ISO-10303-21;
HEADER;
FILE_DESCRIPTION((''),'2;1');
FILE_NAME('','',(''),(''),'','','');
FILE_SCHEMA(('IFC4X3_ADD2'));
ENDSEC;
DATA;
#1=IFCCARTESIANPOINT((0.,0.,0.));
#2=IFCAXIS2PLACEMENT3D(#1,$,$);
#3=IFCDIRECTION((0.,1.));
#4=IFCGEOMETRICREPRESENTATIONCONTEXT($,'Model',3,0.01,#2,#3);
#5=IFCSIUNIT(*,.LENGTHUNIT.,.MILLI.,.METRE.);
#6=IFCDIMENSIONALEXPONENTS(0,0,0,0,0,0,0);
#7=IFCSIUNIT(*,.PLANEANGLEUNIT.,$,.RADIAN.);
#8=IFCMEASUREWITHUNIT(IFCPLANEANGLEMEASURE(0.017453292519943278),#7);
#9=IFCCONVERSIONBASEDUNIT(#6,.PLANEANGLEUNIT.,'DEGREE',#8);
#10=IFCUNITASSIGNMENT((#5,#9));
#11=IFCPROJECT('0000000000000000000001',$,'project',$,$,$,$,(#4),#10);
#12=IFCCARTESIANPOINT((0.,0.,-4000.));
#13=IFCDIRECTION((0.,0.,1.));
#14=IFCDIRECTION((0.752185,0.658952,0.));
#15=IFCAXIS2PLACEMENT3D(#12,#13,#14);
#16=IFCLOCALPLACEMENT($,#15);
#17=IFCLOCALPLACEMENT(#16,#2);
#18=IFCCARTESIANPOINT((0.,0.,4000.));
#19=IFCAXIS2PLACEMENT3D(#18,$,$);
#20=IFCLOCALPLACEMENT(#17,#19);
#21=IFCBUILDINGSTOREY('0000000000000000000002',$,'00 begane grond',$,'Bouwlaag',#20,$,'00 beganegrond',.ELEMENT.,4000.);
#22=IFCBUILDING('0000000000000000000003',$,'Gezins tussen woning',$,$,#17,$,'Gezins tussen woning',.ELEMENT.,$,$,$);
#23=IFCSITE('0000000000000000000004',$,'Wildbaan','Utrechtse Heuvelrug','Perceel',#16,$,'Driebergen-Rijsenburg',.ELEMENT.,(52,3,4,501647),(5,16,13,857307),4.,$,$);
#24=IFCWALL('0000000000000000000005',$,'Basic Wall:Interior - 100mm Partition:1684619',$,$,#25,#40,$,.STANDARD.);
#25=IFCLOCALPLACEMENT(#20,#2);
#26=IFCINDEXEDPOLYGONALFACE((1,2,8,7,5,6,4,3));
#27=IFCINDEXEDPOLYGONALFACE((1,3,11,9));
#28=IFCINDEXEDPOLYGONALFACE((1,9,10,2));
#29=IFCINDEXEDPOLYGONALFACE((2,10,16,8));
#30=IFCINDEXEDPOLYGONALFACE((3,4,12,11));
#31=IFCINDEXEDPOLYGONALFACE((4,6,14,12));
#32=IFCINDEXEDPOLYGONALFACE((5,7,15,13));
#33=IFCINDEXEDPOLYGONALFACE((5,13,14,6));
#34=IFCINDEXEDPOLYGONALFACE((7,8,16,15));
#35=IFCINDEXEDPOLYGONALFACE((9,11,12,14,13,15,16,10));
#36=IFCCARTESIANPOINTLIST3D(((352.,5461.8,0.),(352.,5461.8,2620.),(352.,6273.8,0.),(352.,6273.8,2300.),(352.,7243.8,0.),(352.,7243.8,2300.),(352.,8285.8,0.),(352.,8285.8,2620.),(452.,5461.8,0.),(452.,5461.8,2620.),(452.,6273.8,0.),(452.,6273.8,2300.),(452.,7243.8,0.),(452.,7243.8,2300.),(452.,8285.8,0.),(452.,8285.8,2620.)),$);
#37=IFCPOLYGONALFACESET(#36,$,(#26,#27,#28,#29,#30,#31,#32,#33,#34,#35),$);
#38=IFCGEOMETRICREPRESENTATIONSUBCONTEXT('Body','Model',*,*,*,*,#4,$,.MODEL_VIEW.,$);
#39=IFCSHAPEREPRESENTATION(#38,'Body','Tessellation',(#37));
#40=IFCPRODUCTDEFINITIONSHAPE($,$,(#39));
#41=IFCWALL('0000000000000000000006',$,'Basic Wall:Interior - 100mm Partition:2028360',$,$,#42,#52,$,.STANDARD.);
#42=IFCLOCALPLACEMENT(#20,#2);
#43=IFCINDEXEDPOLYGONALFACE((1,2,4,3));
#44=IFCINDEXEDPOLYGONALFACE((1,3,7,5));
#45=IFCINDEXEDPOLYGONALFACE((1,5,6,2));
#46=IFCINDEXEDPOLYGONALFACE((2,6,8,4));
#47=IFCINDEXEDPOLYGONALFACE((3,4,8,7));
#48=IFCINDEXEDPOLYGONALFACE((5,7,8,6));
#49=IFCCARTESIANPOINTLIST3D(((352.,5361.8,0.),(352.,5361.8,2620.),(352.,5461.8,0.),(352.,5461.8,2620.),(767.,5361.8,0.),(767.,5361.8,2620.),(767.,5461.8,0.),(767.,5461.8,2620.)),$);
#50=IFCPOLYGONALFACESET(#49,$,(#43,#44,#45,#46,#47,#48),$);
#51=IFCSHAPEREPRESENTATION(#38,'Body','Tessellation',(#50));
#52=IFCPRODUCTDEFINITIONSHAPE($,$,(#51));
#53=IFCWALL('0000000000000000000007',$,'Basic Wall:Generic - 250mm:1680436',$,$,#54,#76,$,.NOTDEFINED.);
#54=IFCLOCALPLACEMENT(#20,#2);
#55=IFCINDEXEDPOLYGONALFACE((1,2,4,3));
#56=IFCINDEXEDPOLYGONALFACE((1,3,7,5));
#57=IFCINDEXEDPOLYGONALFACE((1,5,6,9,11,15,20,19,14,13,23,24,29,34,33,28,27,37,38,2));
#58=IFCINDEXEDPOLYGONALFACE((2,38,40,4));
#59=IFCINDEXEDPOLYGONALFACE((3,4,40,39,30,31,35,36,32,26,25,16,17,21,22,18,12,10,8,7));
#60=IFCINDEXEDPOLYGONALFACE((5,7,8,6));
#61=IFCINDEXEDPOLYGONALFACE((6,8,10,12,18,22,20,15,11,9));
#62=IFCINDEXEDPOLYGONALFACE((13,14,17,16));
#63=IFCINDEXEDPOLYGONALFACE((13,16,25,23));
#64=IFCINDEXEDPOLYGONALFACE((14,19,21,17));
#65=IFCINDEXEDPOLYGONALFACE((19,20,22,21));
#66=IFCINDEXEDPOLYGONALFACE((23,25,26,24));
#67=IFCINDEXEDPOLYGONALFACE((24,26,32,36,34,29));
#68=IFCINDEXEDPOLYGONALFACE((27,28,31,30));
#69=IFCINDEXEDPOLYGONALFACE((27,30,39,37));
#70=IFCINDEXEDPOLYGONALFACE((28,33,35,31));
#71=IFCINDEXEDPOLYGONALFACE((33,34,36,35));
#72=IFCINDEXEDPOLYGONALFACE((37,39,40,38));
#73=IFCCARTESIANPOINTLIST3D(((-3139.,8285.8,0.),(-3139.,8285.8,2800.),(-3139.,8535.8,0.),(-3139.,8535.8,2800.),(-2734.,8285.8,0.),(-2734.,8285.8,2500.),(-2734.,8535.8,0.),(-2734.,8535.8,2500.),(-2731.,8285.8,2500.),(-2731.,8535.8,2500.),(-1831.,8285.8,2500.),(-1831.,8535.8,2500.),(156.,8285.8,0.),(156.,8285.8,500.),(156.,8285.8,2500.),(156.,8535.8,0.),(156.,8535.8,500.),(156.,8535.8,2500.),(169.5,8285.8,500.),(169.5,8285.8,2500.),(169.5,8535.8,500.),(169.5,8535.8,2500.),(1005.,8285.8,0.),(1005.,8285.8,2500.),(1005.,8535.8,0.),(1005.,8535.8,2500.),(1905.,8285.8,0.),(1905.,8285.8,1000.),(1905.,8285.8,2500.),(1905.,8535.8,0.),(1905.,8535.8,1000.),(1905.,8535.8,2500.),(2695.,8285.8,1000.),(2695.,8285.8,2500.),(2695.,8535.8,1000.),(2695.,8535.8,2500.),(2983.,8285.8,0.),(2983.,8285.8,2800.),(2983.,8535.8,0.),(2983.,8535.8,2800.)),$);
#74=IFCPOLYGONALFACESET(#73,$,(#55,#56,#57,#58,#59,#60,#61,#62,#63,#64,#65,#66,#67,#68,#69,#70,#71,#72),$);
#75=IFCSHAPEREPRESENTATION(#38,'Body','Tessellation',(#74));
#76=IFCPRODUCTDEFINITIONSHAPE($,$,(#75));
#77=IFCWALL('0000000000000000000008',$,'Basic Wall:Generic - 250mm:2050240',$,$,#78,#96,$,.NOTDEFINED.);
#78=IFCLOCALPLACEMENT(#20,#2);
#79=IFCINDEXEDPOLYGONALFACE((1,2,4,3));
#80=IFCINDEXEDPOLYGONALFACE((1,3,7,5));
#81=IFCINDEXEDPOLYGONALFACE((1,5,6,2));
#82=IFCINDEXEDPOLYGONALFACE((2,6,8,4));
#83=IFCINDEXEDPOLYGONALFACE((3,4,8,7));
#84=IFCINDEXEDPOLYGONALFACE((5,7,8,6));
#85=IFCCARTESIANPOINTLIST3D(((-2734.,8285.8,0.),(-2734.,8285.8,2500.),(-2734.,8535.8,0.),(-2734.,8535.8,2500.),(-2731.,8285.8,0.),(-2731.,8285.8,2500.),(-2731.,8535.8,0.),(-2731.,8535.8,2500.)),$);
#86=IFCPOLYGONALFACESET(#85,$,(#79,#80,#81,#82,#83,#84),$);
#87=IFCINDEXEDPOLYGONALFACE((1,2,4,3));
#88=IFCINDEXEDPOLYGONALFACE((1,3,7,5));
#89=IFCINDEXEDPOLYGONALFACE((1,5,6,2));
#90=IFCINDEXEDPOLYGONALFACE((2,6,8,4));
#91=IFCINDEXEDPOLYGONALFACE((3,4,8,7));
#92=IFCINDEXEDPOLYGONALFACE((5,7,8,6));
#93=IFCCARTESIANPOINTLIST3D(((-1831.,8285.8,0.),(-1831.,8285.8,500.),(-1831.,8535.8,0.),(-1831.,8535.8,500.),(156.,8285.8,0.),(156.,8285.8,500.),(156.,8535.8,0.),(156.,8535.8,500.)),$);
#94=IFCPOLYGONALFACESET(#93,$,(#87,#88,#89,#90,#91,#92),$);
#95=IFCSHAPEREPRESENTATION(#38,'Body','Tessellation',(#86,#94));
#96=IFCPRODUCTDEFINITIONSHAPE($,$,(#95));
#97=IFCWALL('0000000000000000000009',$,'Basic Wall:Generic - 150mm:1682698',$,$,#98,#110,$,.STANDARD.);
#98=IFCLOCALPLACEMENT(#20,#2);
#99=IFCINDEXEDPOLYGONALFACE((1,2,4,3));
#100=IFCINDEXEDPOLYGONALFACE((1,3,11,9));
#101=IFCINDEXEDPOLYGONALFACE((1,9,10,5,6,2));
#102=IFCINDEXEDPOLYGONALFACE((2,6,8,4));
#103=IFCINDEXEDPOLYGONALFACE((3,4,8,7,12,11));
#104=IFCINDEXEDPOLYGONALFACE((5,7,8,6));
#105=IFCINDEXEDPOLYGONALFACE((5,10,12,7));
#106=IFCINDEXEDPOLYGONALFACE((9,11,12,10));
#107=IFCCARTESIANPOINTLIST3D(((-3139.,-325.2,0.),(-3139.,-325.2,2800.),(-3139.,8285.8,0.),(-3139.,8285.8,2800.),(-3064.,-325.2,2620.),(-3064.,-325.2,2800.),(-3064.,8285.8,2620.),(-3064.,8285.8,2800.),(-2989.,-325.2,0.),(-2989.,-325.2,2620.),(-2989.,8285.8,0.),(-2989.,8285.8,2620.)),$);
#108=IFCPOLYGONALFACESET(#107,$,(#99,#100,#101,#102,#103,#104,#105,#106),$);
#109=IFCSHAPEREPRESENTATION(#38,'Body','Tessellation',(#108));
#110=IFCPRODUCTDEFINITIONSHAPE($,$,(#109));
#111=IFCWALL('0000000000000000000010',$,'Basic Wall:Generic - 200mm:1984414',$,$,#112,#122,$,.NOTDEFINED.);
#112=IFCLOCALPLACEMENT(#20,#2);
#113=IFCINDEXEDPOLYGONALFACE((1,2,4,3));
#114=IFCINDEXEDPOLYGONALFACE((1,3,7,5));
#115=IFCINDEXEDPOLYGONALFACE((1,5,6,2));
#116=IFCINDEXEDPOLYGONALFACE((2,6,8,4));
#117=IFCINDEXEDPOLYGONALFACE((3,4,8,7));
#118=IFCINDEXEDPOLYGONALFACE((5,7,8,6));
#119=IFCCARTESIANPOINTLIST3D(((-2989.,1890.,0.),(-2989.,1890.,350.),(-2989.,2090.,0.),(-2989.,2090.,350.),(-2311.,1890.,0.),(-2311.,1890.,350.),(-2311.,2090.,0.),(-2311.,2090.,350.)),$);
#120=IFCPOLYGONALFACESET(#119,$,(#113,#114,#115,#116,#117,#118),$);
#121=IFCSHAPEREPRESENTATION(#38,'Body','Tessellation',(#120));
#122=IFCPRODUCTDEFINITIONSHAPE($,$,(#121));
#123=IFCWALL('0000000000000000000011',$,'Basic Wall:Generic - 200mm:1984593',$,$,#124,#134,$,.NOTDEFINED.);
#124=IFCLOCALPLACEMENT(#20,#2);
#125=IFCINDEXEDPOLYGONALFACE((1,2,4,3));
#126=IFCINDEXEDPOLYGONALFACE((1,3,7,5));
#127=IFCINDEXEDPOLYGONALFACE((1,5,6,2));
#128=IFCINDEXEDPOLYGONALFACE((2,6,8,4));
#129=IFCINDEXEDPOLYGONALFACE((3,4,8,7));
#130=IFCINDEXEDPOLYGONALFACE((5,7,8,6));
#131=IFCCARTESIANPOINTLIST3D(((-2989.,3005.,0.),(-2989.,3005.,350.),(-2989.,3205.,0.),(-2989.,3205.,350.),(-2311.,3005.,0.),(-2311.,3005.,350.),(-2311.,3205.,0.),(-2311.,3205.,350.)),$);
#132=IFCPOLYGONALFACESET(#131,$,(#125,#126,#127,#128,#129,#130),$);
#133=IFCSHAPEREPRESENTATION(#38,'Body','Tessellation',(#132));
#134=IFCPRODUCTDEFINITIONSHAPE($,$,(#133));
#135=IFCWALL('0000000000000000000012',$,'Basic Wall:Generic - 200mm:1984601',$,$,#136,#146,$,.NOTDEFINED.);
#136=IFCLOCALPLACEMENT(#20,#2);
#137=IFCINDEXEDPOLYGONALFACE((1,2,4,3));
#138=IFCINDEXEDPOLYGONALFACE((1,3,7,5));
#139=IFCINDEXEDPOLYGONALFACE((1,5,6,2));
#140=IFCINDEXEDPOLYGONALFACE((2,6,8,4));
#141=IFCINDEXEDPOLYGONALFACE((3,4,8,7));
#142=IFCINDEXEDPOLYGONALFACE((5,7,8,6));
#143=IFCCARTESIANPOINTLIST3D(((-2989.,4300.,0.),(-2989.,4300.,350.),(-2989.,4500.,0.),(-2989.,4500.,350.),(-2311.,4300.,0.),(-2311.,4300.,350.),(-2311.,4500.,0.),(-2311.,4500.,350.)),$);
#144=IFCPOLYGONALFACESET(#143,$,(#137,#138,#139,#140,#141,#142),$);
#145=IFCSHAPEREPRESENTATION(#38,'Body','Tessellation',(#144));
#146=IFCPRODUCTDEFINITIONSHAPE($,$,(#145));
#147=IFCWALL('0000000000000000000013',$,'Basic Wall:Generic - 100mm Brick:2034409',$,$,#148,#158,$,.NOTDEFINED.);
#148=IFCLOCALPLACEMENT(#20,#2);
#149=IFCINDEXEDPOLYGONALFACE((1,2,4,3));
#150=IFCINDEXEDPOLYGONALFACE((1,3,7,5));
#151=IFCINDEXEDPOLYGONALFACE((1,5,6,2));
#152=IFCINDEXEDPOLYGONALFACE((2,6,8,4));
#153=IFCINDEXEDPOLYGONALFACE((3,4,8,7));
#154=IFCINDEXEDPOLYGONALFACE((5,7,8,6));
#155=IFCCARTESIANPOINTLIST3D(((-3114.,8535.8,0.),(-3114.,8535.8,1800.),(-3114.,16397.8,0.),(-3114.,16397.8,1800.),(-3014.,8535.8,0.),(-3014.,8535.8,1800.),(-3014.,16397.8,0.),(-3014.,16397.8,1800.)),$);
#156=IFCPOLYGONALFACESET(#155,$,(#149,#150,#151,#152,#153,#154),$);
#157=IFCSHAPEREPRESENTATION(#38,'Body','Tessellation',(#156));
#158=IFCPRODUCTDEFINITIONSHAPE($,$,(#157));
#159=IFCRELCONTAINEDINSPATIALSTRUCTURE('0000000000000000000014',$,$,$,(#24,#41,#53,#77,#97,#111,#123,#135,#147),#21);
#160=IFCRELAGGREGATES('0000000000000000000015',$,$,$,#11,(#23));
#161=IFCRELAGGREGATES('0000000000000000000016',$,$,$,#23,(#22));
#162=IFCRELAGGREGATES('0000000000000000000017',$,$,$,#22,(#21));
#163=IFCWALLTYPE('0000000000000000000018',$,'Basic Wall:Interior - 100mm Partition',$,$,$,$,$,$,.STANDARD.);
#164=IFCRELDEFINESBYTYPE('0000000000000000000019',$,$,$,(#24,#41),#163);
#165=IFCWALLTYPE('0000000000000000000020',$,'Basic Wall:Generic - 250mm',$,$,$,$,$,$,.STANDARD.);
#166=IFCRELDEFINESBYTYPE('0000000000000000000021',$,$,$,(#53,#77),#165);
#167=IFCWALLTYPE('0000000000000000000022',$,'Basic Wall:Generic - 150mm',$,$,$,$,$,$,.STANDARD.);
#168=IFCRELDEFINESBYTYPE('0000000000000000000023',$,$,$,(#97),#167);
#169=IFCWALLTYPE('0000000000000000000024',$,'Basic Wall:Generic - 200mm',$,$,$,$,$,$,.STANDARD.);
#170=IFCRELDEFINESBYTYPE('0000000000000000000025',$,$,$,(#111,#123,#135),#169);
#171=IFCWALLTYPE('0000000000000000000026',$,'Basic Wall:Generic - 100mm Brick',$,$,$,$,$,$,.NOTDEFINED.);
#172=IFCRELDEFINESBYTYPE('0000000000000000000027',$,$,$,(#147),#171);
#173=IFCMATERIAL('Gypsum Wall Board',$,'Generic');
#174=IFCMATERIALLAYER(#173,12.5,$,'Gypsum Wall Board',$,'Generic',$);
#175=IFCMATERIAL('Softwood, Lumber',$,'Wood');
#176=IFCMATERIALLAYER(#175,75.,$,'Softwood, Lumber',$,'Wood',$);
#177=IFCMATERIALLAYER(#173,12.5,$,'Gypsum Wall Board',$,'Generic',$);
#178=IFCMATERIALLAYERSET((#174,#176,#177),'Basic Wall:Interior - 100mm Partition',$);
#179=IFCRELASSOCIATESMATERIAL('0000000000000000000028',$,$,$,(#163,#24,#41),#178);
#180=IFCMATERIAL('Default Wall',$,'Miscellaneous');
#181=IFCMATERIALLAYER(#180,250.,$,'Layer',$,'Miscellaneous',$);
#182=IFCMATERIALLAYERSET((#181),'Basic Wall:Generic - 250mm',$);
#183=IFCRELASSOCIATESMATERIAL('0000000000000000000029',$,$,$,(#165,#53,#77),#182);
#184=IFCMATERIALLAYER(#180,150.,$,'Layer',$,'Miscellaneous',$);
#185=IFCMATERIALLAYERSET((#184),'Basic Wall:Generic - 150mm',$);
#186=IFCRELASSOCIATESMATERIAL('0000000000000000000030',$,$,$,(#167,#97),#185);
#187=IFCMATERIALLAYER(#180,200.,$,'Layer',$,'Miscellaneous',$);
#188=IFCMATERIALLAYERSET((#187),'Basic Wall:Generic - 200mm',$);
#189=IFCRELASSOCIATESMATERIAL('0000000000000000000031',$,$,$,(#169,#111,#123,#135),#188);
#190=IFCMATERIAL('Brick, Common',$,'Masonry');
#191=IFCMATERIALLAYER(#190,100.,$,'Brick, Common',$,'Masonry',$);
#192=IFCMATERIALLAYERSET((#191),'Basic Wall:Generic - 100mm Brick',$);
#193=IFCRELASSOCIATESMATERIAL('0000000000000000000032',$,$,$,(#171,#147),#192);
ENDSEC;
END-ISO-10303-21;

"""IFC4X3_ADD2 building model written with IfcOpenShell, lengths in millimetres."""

from ifc_helpers import new_model, entity, si_unit, converted_unit, direction, frame, frame_2d, origin, place, context, subcontext, project, spatial, polyline, rectangle, extrude, clip, bounded_halfspace, material, layer, layer_set, type_object, element, save


model = new_model("IFC4X3_ADD2")

# Units and contexts
model_context = context("Model", 3, precision=0.01, world=origin(), true_north=direction((0.0, 1.0)))
body_context = subcontext(model_context, "Body", "Model", "MODEL_VIEW")
ifc_project = project(units=[si_unit("LENGTHUNIT", "METRE", prefix="MILLI"), converted_unit("PLANEANGLEUNIT", "DEGREE", entity("IfcPlaneAngleMeasure", 0.017453292519943278), si_unit("PLANEANGLEUNIT", "RADIAN"), dimensions=[0, 0, 0, 0, 0, 0, 0])], contexts=[model_context])

# Site, building, storey
site_placement = place(None, frame((0.0, 0.0, -4000.0), z_axis=(0.0, 0.0, 1.0), x_axis=(0.752185, 0.658952, 0.0)))
site = spatial("IfcSite", under=ifc_project, at=site_placement, Name="Wildbaan", Description="Utrechtse Heuvelrug", ObjectType="Perceel", LongName="Driebergen-Rijsenburg", CompositionType="ELEMENT", RefLatitude=(52, 3, 4, 501647), RefLongitude=(5, 16, 13, 857307), RefElevation=4.0)
building_placement = place(site_placement, origin())
building = spatial("IfcBuilding", under=site, at=building_placement, Name="Gezins tussen woning", LongName="Gezins tussen woning", CompositionType="ELEMENT")
storey_placement = place(building_placement, frame((0.0, 0.0, 4000.0)))
storey = spatial("IfcBuildingStorey", under=building, at=storey_placement, Name="00 begane grond", ObjectType="Bouwlaag", LongName="00 beganegrond", CompositionType="ELEMENT", Elevation=4000.0)

# Wall, opening
ifc_material_1 = material(Name="Gypsum Wall Board", Category="Generic")
ifc_layer_1 = layer(ifc_material_1, 12.5, Name="Gypsum Wall Board", Category="Generic")
ifc_material_2 = material(Name="Softwood, Lumber", Category="Wood")
ifc_layer_2 = layer(ifc_material_2, 75.0, Name="Softwood, Lumber", Category="Wood")
ifc_layer_3 = layer(ifc_material_1, 12.5, Name="Gypsum Wall Board", Category="Generic")
ifc_layer_set_1 = layer_set([ifc_layer_1, ifc_layer_2, ifc_layer_3], Name="Basic Wall:Interior - 100mm Partition")
wall_type_1 = type_object("IfcWallType", Name="Basic Wall:Interior - 100mm Partition", PredefinedType="STANDARD", material=ifc_layer_set_1)
wall_1_placement = place(storey_placement, frame((402.0, 5461.8, 0.0), z_axis=(0.0, 0.0, 1.0), x_axis=(0.0, 1.0, 0.0)))
wall_1 = element("IfcWall", 1, at=wall_1_placement, inside=storey, type_object=wall_type_1, material=ifc_layer_set_1, Name="Basic Wall:Interior - 100mm Partition:1684619", PredefinedType="STANDARD", context=body_context, shape_type="SweptSolid", body=[
    extrude(rectangle(XDim=2824.0, YDim=100.0, at=frame_2d((1412.0, 0.0), x_axis=(1.0, 0.0))), origin(), (0.0, 0.0, 1.0), 2620.0),
])
opening_1_placement = place(wall_1_placement, frame((-5461.8, 402.0, 0.0), z_axis=(0.0, 0.0, 1.0), x_axis=(0.0, -1.0, 0.0)))
element("IfcOpeningElement", 2, at=opening_1_placement, cuts=wall_1, PredefinedType="OPENING", context=body_context, shape_type="SweptSolid", body=[
    extrude(rectangle(XDim=2300.0, YDim=970.0, at=frame_2d((0.0, 0.0), x_axis=(1.0, 0.0))), frame((452.0, 6758.8, 1150.0), z_axis=(-1.0, 0.0, 0.0), x_axis=(0.0, 0.0, -1.0)), (0.0, 0.0, 1.0), 100.0),
])

# Wall
wall_2_placement = place(storey_placement, frame((767.0, 5411.8, 0.0), z_axis=(0.0, 0.0, 1.0), x_axis=(-1.0, 0.0, 0.0)))
element("IfcWall", 3, at=wall_2_placement, inside=storey, type_object=wall_type_1, material=ifc_layer_set_1, Name="Basic Wall:Interior - 100mm Partition:2028360", PredefinedType="STANDARD", context=body_context, shape_type="SweptSolid", body=[
    extrude(rectangle(XDim=415.0, YDim=100.0, at=frame_2d((207.5, 0.0), x_axis=(-1.0, 0.0))), origin(), (0.0, 0.0, 1.0), 2620.0),
])

# Wall, openings
ifc_material_3 = material(Name="Default Wall", Category="Miscellaneous")
ifc_layer_4 = layer(ifc_material_3, 250.0, Name="Layer", Category="Miscellaneous")
ifc_layer_set_2 = layer_set([ifc_layer_4], Name="Basic Wall:Generic - 250mm")
wall_type_2 = type_object("IfcWallType", Name="Basic Wall:Generic - 250mm", PredefinedType="STANDARD", material=ifc_layer_set_2)
wall_3_placement = place(storey_placement, frame((-3139.0, 8410.8, 0.0)))
wall_3 = element("IfcWall", 4, at=wall_3_placement, inside=storey, type_object=wall_type_2, material=ifc_layer_set_2, Name="Basic Wall:Generic - 250mm:1680436", PredefinedType="NOTDEFINED", context=body_context, shape_type="SweptSolid", body=[
    extrude(rectangle(XDim=6122.0, YDim=250.0, at=frame_2d((3061.0, 0.0), x_axis=(-1.0, 0.0))), origin(), (0.0, 0.0, 1.0), 2800.0),
])
opening_2_placement = place(wall_3_placement, frame((3139.0, -8410.8, 0.0)))
element("IfcOpeningElement", 5, at=opening_2_placement, cuts=wall_3, PredefinedType="OPENING", context=body_context, shape_type="SweptSolid", body=[
    extrude(rectangle(XDim=2500.0, YDim=900.0, at=frame_2d((0.0, 0.0), x_axis=(1.0, 0.0))), frame((-2281.0, 8285.8, 1250.0), z_axis=(0.0, 1.0, 0.0), x_axis=(0.0, 0.0, -1.0)), (0.0, 0.0, 1.0), 250.0),
])
opening_3_placement = place(wall_3_placement, frame((3139.0, -8410.8, 500.0)))
element("IfcOpeningElement", 6, at=opening_3_placement, cuts=wall_3, PredefinedType="OPENING", context=body_context, shape_type="SweptSolid", body=[
    extrude(rectangle(XDim=2000.0, YDim=2000.5, at=frame_2d((0.0, 0.0), x_axis=(1.0, 0.0))), frame((-830.7, 8285.8, 1000.0), z_axis=(0.0, 1.0, 0.0), x_axis=(0.0, 0.0, -1.0)), (0.0, 0.0, 1.0), 250.0),
])
opening_4_placement = place(wall_3_placement, frame((3139.0, -8410.8, 0.0)))
element("IfcOpeningElement", 7, at=opening_4_placement, cuts=wall_3, PredefinedType="OPENING", context=body_context, shape_type="SweptSolid", body=[
    extrude(rectangle(XDim=2500.0, YDim=900.0, at=frame_2d((0.0, 0.0), x_axis=(1.0, 0.0))), frame((1455.0, 8285.8, 1250.0), z_axis=(0.0, 1.0, 0.0), x_axis=(0.0, 0.0, -1.0)), (0.0, 0.0, 1.0), 250.0),
])
opening_5_placement = place(wall_3_placement, frame((3139.0, -8410.8, 1000.0)))
element("IfcOpeningElement", 8, at=opening_5_placement, cuts=wall_3, PredefinedType="OPENING", context=body_context, shape_type="SweptSolid", body=[
    extrude(rectangle(XDim=1500.0, YDim=790.0, at=frame_2d((0.0, 0.0), x_axis=(1.0, 0.0))), frame((2300.0, 8285.8, 750.0), z_axis=(0.0, 1.0, 0.0), x_axis=(0.0, 0.0, -1.0)), (0.0, 0.0, 1.0), 250.0),
])
opening_6_placement = place(wall_3_placement, frame((3139.0, -8410.8, 0.0)))
element("IfcOpeningElement", 9, at=opening_6_placement, cuts=wall_3, PredefinedType="OPENING", context=body_context, shape_type="SweptSolid", body=[
    extrude(rectangle(XDim=2500.0, YDim=2890.0, at=frame_2d((0.0, 0.0), x_axis=(0.0, 1.0))), frame((-1289.0, 8285.8, 1250.0), z_axis=(0.0, 1.0, 0.0), x_axis=(1.0, 0.0, 0.0)), (0.0, 0.0, 1.0), 250.0),
])

# Walls
wall_4_placement = place(storey_placement, frame((-2734.0, 8410.8, 0.0)))
element("IfcWall", 10, at=wall_4_placement, inside=storey, type_object=wall_type_2, material=ifc_layer_set_2, Name="Basic Wall:Generic - 250mm:2050240", PredefinedType="NOTDEFINED", context=body_context, shape_type="SweptSolid", body=[
    extrude(rectangle(XDim=3.0, YDim=250.0, at=frame_2d((0.0, 0.0), x_axis=(1.0, 0.0))), frame((1.5, 0.0, 0.0)), (0.0, 0.0, 1.0), 2500.0),
    extrude(rectangle(XDim=1987.0, YDim=250.0, at=frame_2d((0.0, 0.0), x_axis=(1.0, 0.0))), frame((1896.5, 0.0, 0.0), z_axis=(0.0, 0.0, 1.0), x_axis=(-1.0, 0.0, 0.0)), (0.0, 0.0, 1.0), 500.0),
])
ifc_layer_5 = layer(ifc_material_3, 150.0, Name="Layer", Category="Miscellaneous")
ifc_layer_set_3 = layer_set([ifc_layer_5], Name="Basic Wall:Generic - 150mm")
wall_type_3 = type_object("IfcWallType", Name="Basic Wall:Generic - 150mm", PredefinedType="STANDARD", material=ifc_layer_set_3)
wall_5_placement = place(storey_placement, frame((-3064.0, -325.2, 0.0), z_axis=(0.0, 0.0, 1.0), x_axis=(0.0, 1.0, 0.0)))
element("IfcWall", 11, at=wall_5_placement, inside=storey, type_object=wall_type_3, material=ifc_layer_set_3, Name="Basic Wall:Generic - 150mm:1682698", PredefinedType="STANDARD", context=body_context, shape_type="Clipping", body=[
    clip(extrude(rectangle(XDim=8611.0, YDim=150.0, at=frame_2d((4305.5, 0.0), x_axis=(-1.0, 0.0))), origin(), (0.0, 0.0, 1.0), 2800.0), bounded_halfspace(frame((0.0, -75.0, 2620.0), z_axis=(0.0, 0.0, -1.0), x_axis=(-1.0, 0.0, 0.0)), True, frame((0.0, -75.0, 2620.0)), polyline([(0.0, 0.0), (8611.0, 0.0), (8611.0, 75.0), (0.0, 75.0), (0.0, 0.0)]))),
])

# Walls
ifc_layer_6 = layer(ifc_material_3, 200.0, Name="Layer", Category="Miscellaneous")
ifc_layer_set_4 = layer_set([ifc_layer_6], Name="Basic Wall:Generic - 200mm")
wall_type_4 = type_object("IfcWallType", Name="Basic Wall:Generic - 200mm", PredefinedType="STANDARD", material=ifc_layer_set_4)
for number, where, name in (
    (12, (-2989.0, 1990.0, 0.0), "Basic Wall:Generic - 200mm:1984414"),
    (13, (-2989.0, 3105.0, 0.0), "Basic Wall:Generic - 200mm:1984593"),
):
    element("IfcWall", number, at=place(storey_placement, frame(where)), inside=storey, type_object=wall_type_4, material=ifc_layer_set_4, Name=name, PredefinedType="NOTDEFINED", context=body_context, shape_type="SweptSolid", body=[
        extrude(rectangle(XDim=678.0, YDim=200.0, at=frame_2d((339.0, 0.0), x_axis=(-1.0, 0.0))), origin(), (0.0, 0.0, 1.0), 350.0),
    ])
wall_6_placement = place(storey_placement, frame((-2989.0, 4400.0, 0.0)))
element("IfcWall", 14, at=wall_6_placement, inside=storey, type_object=wall_type_4, material=ifc_layer_set_4, Name="Basic Wall:Generic - 200mm:1984601", PredefinedType="NOTDEFINED", context=body_context, shape_type="SweptSolid", body=[
    extrude(rectangle(XDim=678.0, YDim=200.0, at=frame_2d((339.0, 0.0), x_axis=(-1.0, 0.0))), origin(), (0.0, 0.0, 1.0), 350.0),
])
ifc_material_4 = material(Name="Brick, Common", Category="Masonry")
ifc_layer_7 = layer(ifc_material_4, 100.0, Name="Brick, Common", Category="Masonry")
ifc_layer_set_5 = layer_set([ifc_layer_7], Name="Basic Wall:Generic - 100mm Brick")
wall_type_5 = type_object("IfcWallType", Name="Basic Wall:Generic - 100mm Brick", PredefinedType="NOTDEFINED", material=ifc_layer_set_5)
wall_7_placement = place(storey_placement, frame((-3064.0, 8535.8, 0.0), z_axis=(0.0, 0.0, 1.0), x_axis=(0.0, 1.0, 0.0)))
element("IfcWall", 15, at=wall_7_placement, inside=storey, type_object=wall_type_5, material=ifc_layer_set_5, Name="Basic Wall:Generic - 100mm Brick:2034409", PredefinedType="NOTDEFINED", context=body_context, shape_type="SweptSolid", body=[
    extrude(rectangle(XDim=7862.0, YDim=100.0, at=frame_2d((3931.0, 0.0), x_axis=(-1.0, 0.0))), origin(), (0.0, 0.0, 1.0), 1800.0),
])

save(model, "model.ifc")
